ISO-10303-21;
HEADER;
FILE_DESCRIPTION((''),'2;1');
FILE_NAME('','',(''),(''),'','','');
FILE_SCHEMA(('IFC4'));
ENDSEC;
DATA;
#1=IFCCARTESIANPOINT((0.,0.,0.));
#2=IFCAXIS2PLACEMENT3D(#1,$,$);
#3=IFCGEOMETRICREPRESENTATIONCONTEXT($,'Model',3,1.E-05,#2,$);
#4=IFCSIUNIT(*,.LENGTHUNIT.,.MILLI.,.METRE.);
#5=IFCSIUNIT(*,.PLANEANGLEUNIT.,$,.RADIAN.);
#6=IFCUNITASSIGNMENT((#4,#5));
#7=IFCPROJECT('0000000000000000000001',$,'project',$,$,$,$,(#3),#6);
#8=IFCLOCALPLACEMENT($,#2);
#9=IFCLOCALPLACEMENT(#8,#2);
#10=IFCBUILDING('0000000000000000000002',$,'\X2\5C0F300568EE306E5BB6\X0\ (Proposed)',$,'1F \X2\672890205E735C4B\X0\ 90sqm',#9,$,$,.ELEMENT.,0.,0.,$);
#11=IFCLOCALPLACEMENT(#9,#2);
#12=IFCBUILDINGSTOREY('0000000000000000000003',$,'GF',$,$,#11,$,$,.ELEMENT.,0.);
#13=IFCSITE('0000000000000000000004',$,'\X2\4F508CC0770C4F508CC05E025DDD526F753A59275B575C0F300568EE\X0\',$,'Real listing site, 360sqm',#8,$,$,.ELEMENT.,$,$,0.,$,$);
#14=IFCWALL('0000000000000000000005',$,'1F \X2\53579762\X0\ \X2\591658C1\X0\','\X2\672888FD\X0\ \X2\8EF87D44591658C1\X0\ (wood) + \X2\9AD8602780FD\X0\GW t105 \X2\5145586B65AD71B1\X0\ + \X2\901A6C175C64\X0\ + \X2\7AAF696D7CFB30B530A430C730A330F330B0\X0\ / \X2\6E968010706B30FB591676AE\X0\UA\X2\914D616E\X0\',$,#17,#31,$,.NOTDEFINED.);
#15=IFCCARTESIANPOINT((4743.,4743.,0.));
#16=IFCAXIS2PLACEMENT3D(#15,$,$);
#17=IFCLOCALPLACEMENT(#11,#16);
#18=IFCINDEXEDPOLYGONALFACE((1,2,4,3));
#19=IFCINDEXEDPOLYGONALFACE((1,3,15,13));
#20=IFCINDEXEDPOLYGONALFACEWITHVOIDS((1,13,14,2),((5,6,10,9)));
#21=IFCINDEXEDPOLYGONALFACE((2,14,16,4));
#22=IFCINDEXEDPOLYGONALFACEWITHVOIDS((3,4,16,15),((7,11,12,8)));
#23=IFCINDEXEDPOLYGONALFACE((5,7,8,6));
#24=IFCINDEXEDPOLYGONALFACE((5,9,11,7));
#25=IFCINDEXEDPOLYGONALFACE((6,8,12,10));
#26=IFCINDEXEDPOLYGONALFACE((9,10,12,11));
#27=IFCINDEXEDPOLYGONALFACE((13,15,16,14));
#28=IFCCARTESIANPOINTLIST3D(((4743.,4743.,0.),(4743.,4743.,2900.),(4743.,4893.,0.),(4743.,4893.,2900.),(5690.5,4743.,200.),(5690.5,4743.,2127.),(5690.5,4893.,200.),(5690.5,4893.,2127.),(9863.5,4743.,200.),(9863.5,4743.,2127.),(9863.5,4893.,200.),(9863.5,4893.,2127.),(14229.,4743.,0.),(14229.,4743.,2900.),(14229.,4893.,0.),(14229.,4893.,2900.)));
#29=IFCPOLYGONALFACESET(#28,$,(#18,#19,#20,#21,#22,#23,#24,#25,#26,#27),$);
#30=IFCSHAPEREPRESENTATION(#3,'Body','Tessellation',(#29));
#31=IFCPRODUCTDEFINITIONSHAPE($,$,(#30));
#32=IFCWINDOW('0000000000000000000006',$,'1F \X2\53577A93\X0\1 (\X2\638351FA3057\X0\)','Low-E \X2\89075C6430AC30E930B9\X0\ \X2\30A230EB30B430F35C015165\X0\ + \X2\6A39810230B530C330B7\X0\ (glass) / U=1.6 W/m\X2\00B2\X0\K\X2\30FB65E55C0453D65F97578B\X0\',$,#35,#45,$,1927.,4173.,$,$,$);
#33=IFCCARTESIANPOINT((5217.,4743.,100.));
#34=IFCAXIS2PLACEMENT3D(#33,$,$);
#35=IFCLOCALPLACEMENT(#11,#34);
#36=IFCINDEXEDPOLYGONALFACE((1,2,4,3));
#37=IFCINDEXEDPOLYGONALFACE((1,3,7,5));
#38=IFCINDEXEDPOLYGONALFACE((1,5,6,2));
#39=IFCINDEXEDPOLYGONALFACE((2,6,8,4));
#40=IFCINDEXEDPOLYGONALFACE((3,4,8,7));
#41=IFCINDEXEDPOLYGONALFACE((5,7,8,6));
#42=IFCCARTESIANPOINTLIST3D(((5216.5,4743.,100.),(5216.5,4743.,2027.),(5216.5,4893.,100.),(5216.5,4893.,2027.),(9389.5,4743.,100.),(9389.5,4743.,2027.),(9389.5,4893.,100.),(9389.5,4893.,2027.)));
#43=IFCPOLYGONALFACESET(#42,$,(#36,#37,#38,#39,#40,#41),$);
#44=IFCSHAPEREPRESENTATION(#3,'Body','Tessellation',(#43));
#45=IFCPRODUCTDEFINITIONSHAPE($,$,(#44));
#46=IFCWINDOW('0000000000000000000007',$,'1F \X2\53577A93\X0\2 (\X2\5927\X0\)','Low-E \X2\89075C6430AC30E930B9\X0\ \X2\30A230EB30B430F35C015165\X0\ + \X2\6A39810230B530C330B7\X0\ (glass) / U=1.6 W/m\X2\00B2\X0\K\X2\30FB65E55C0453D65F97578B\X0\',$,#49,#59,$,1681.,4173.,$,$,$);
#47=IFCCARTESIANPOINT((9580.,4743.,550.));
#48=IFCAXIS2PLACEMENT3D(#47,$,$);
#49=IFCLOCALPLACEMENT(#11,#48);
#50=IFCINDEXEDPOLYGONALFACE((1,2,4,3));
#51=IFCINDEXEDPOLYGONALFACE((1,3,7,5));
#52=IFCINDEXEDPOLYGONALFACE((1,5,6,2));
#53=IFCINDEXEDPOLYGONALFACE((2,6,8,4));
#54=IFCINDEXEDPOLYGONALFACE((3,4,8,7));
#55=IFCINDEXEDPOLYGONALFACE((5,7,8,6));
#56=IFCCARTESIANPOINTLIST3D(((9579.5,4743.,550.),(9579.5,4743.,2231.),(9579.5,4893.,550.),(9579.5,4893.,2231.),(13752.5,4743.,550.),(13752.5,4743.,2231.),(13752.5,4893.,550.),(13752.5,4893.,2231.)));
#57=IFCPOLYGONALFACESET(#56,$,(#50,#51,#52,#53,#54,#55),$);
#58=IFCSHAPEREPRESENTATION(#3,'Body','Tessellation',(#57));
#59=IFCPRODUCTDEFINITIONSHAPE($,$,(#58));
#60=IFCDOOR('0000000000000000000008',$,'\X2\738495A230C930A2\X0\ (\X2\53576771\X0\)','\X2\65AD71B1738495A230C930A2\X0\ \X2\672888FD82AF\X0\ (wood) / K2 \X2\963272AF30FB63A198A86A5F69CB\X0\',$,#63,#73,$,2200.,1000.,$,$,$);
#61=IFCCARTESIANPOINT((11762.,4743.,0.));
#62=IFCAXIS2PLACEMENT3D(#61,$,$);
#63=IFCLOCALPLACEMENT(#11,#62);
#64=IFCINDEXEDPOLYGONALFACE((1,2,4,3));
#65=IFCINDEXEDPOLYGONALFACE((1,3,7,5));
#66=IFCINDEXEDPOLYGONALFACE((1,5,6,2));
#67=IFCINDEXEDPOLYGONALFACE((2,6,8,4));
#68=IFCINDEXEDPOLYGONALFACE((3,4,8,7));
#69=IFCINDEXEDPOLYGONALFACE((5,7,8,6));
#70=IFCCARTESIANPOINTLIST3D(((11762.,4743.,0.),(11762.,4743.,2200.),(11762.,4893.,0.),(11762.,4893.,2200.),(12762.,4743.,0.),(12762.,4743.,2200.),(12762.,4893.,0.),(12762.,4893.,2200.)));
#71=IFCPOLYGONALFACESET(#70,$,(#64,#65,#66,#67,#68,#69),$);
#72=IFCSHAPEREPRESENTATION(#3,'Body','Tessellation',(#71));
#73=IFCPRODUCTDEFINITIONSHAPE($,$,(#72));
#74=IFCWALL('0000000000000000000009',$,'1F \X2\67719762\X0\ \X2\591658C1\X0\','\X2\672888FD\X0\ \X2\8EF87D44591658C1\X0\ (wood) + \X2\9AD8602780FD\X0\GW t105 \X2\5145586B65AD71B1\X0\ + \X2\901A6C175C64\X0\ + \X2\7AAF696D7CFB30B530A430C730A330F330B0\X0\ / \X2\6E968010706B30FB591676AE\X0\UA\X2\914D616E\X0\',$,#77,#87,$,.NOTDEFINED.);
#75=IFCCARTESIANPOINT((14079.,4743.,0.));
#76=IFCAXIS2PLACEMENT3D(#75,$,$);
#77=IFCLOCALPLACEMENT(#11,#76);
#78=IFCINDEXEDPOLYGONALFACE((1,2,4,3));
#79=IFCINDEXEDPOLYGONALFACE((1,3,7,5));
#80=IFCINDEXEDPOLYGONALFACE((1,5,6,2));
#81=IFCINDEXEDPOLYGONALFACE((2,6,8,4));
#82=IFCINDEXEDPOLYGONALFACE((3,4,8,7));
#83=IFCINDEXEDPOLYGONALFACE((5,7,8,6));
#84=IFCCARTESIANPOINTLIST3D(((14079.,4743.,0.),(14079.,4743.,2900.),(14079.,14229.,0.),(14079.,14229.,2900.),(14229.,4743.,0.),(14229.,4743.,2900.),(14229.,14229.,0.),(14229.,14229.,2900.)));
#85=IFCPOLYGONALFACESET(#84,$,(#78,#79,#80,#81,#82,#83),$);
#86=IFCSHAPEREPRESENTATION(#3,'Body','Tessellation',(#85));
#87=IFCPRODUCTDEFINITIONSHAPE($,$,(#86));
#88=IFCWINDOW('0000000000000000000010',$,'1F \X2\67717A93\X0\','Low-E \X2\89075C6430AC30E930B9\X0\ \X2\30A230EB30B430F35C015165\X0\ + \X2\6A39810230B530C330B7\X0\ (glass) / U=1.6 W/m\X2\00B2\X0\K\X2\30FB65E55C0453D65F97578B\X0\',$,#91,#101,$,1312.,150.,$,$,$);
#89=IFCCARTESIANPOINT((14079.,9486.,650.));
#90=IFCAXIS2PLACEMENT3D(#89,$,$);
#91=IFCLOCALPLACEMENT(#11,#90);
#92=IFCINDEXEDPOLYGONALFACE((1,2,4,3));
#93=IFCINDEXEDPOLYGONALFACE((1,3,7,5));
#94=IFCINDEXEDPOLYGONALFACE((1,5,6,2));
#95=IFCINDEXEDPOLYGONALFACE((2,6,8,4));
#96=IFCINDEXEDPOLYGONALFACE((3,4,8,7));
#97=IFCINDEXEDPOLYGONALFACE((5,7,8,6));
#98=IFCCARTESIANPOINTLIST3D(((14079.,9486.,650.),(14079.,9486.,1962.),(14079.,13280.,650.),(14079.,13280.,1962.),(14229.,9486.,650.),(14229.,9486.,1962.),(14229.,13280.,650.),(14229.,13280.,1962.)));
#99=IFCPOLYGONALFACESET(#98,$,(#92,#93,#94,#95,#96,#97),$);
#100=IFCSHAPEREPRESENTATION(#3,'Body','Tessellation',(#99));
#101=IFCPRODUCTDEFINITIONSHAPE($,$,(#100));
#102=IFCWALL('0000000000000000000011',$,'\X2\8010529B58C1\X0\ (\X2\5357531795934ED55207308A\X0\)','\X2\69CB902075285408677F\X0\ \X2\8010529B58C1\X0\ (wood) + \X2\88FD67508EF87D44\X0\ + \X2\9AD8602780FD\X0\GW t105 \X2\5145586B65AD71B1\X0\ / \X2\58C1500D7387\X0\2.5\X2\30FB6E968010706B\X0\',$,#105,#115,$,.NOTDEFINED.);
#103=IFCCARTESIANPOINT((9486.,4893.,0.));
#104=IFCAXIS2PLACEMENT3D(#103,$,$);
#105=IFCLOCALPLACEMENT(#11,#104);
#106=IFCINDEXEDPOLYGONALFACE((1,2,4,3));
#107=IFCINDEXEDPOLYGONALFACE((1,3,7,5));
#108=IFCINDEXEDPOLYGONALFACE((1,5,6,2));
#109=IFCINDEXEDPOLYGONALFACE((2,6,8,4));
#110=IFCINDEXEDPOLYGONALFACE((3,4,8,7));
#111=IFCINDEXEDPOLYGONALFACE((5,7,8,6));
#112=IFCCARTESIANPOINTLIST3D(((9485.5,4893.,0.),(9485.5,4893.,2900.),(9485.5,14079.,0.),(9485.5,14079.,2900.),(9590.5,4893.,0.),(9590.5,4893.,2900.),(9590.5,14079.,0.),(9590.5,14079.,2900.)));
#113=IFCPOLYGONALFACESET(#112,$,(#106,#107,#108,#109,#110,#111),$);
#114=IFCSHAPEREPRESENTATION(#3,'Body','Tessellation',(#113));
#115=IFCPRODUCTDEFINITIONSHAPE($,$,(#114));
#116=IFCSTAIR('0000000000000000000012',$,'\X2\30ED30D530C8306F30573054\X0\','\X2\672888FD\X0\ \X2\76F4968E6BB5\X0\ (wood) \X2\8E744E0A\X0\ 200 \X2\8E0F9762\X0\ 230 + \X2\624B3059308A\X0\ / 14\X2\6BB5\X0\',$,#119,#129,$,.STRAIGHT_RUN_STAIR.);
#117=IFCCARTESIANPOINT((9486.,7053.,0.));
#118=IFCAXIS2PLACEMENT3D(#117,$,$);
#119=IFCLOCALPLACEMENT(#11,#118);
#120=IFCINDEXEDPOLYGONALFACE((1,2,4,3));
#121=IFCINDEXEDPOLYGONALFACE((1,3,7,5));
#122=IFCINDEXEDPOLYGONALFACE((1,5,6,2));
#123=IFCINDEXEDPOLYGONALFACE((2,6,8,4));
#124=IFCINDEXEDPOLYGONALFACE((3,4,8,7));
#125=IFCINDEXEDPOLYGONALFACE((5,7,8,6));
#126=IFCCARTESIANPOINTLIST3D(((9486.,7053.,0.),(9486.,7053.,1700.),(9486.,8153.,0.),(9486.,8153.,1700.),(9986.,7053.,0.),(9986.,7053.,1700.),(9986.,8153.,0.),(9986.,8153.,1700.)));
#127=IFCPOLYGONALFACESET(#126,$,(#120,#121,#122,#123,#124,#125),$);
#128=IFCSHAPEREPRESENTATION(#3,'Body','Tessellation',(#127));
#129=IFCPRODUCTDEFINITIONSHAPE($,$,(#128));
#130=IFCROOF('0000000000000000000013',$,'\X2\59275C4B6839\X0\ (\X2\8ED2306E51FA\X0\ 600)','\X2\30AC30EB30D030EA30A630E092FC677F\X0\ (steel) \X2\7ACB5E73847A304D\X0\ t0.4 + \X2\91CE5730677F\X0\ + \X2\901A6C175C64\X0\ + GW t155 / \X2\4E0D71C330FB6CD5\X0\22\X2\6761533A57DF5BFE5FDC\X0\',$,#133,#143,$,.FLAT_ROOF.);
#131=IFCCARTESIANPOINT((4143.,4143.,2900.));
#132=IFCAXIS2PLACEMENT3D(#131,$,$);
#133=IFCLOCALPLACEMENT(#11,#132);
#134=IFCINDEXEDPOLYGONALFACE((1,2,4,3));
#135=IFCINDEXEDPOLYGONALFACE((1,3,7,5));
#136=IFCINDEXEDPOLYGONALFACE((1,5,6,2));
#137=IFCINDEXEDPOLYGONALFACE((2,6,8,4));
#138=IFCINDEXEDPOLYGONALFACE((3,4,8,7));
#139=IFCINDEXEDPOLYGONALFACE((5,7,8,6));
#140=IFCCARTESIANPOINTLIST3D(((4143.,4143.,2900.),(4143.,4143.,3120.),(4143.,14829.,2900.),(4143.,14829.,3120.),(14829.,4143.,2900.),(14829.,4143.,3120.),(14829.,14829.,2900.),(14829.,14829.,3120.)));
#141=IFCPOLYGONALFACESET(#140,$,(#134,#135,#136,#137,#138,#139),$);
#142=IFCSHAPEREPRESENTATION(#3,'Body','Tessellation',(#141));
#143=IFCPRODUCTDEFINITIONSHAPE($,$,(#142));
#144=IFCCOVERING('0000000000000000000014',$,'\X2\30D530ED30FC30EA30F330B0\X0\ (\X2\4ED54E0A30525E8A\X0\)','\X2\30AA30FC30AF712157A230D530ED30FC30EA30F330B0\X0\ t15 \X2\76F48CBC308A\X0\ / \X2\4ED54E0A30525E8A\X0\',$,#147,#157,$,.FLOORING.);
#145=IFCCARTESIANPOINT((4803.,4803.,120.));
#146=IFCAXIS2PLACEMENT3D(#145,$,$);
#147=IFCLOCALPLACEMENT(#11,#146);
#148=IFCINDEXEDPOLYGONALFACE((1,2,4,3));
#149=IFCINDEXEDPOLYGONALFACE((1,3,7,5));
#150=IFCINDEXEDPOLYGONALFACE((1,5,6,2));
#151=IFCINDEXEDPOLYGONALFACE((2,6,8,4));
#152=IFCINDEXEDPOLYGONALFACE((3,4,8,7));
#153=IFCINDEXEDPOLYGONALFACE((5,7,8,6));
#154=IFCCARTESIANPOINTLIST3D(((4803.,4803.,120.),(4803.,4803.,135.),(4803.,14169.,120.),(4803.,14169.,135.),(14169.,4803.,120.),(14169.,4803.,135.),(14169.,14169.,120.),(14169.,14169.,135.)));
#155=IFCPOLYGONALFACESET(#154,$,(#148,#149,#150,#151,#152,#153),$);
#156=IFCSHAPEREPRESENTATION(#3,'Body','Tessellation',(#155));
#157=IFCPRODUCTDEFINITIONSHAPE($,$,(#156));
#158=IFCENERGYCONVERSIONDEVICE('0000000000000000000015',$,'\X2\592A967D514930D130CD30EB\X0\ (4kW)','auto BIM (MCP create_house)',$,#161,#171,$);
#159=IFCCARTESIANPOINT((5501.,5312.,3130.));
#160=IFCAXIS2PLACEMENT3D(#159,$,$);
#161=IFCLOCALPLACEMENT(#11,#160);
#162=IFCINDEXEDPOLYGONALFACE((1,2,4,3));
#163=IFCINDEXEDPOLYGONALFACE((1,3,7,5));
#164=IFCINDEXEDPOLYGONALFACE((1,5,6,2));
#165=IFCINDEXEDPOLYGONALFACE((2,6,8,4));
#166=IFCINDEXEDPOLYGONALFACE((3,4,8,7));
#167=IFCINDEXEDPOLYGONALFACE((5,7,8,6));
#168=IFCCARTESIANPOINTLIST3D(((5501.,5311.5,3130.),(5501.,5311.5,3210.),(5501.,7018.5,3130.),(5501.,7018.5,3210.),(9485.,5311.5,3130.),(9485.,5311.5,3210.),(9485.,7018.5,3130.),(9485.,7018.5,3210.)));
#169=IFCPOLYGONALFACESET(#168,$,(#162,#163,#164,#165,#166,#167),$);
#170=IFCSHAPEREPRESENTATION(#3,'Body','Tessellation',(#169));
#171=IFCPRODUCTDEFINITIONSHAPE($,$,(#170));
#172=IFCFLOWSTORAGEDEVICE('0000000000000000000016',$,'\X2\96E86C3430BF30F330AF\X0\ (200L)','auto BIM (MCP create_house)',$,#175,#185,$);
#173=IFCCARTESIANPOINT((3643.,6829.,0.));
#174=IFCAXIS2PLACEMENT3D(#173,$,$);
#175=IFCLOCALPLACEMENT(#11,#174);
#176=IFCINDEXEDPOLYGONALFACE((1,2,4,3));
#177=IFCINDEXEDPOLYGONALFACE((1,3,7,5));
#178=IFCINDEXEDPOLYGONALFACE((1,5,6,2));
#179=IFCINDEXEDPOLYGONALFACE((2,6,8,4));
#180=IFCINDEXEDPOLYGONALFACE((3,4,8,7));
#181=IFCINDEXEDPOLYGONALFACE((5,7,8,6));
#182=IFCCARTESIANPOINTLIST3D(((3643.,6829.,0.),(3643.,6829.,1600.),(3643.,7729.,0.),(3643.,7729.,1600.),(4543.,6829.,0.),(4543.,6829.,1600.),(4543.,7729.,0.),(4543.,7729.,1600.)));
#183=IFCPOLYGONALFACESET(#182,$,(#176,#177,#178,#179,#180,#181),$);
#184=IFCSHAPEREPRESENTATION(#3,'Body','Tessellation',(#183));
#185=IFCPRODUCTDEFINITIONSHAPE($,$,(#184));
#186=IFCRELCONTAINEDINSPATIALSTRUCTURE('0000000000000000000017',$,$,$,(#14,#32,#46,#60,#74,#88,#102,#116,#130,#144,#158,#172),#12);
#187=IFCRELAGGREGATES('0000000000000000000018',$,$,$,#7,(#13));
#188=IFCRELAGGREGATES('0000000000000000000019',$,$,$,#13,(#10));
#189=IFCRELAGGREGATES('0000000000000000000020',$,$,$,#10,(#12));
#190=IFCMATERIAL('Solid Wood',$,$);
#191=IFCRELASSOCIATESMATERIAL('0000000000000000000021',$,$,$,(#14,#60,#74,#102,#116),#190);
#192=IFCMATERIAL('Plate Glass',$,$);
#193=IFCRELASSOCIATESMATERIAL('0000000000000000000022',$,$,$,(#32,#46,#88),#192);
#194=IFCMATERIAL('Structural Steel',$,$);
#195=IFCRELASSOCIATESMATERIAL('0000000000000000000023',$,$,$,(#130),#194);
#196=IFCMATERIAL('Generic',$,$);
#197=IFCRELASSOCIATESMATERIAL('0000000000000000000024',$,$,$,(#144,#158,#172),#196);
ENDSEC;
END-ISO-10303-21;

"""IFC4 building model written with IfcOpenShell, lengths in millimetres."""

from ifc_helpers import new_model, si_unit, frame, frame_2d, origin, place, context, project, spatial, rectangle, extrude, material, element, fill, save


model = new_model("IFC4")

# Units and contexts
model_context = context("Model", 3, precision=1e-05, world=origin())
ifc_project = project(units=[si_unit("LENGTHUNIT", "METRE", prefix="MILLI"), si_unit("PLANEANGLEUNIT", "RADIAN")], contexts=[model_context])

# Site, building, storey
site_placement = place(None, origin())
site = spatial("IfcSite", under=ifc_project, at=site_placement, Name="佐賀県佐賀市川副町大字小々森", ObjectType="Real listing site, 360sqm", CompositionType="ELEMENT", RefElevation=0.0)
building_placement = place(site_placement, origin())
building = spatial("IfcBuilding", under=site, at=building_placement, Name="小々森の家 (Proposed)", ObjectType="1F 木造平屋 90sqm", CompositionType="ELEMENT", ElevationOfRefHeight=0.0, ElevationOfTerrain=0.0)
storey_placement = place(building_placement, origin())
storey = spatial("IfcBuildingStorey", under=building, at=storey_placement, Name="GF", CompositionType="ELEMENT", Elevation=0.0)

# Shared definitions
ifc_material_1 = material(Name="Solid Wood")

# Wall, openings, windows, door
wall_1_placement = place(storey_placement, frame((4743.0, 4743.0, 0.0)))
wall_1 = element("IfcWall", 1, at=wall_1_placement, inside=storey, material=ifc_material_1, Name="1F 南面 外壁", Description="木製 軸組外壁 (wood) + 高性能GW t105 充填断熱 + 通気層 + 窯業系サイディング / 準耐火・外皮UA配慮", PredefinedType="NOTDEFINED", context=model_context, shape_type="SweptSolid", body=[
    extrude(rectangle(XDim=9486.0, YDim=150.0, at=frame_2d((4743.0, 75.0))), frame((4743.0, 4743.0, 0.0)), (0.0, 0.0, 1.0), 2900.0),
])
opening_1_placement = place(storey_placement, frame((5217.0, 4743.0, 100.0)))
opening_1 = element("IfcOpeningElement", 2, at=opening_1_placement, cuts=wall_1, PredefinedType="NOTDEFINED", context=model_context, shape_type="SweptSolid", body=[
    extrude(rectangle(XDim=4173.0, YDim=150.0, at=frame_2d((2086.0, 75.0))), frame((5217.0, 4743.0, 100.0)), (0.0, 0.0, 1.0), 1927.0),
])
opening_2_placement = place(storey_placement, frame((9580.0, 4743.0, 550.0)))
opening_2 = element("IfcOpeningElement", 3, at=opening_2_placement, cuts=wall_1, PredefinedType="NOTDEFINED", context=model_context, shape_type="SweptSolid", body=[
    extrude(rectangle(XDim=4173.0, YDim=150.0, at=frame_2d((2086.0, 75.0))), frame((9580.0, 4743.0, 550.0)), (0.0, 0.0, 1.0), 1681.0),
])
opening_3_placement = place(storey_placement, frame((11762.0, 4743.0, 0.0)))
opening_3 = element("IfcOpeningElement", 4, at=opening_3_placement, cuts=wall_1, PredefinedType="NOTDEFINED", context=model_context, shape_type="SweptSolid", body=[
    extrude(rectangle(XDim=1000.0, YDim=150.0, at=frame_2d((500.0, 75.0))), frame((11762.0, 4743.0, 0.0)), (0.0, 0.0, 1.0), 2200.0),
])
ifc_material_2 = material(Name="Plate Glass")
window_1_placement = place(storey_placement, frame((5217.0, 4743.0, 100.0)))
window_1 = element("IfcWindow", 5, at=window_1_placement, inside=storey, material=ifc_material_2, Name="1F 南窓1 (掃出し)", Description="Low-E 複層ガラス アルゴン封入 + 樹脂サッシ (glass) / U=1.6 W/m²K・日射取得型", OverallHeight=1927.0, OverallWidth=4173.0, context=model_context, shape_type="SweptSolid", body=[
    extrude(rectangle(XDim=4173.0, YDim=150.0, at=frame_2d((2086.0, 75.0))), frame((5217.0, 4743.0, 100.0)), (0.0, 0.0, 1.0), 1927.0),
])
fill(opening_1, window_1)
window_2_placement = place(storey_placement, frame((9580.0, 4743.0, 550.0)))
window_2 = element("IfcWindow", 6, at=window_2_placement, inside=storey, material=ifc_material_2, Name="1F 南窓2 (大)", Description="Low-E 複層ガラス アルゴン封入 + 樹脂サッシ (glass) / U=1.6 W/m²K・日射取得型", OverallHeight=1681.0, OverallWidth=4173.0, context=model_context, shape_type="SweptSolid", body=[
    extrude(rectangle(XDim=4173.0, YDim=150.0, at=frame_2d((2086.0, 75.0))), frame((9580.0, 4743.0, 550.0)), (0.0, 0.0, 1.0), 1681.0),
])
fill(opening_2, window_2)
door_placement = place(storey_placement, frame((11762.0, 4743.0, 0.0)))
door = element("IfcDoor", 7, at=door_placement, inside=storey, material=ifc_material_1, Name="玄関ドア (南東)", Description="断熱玄関ドア 木製芯 (wood) / K2 防犯・採風機構", OverallHeight=2200.0, OverallWidth=1000.0, context=model_context, shape_type="SweptSolid", body=[
    extrude(rectangle(XDim=1000.0, YDim=150.0, at=frame_2d((500.0, 75.0))), frame((11762.0, 4743.0, 0.0)), (0.0, 0.0, 1.0), 2200.0),
])
fill(opening_3, door)

# Wall, opening, window
wall_2_placement = place(storey_placement, frame((14079.0, 4743.0, 0.0)))
wall_2 = element("IfcWall", 8, at=wall_2_placement, inside=storey, material=ifc_material_1, Name="1F 東面 外壁", Description="木製 軸組外壁 (wood) + 高性能GW t105 充填断熱 + 通気層 + 窯業系サイディング / 準耐火・外皮UA配慮", PredefinedType="NOTDEFINED", context=model_context, shape_type="SweptSolid", body=[
    extrude(rectangle(XDim=150.0, YDim=9486.0, at=frame_2d((75.0, 4743.0))), frame((14079.0, 4743.0, 0.0)), (0.0, 0.0, 1.0), 2900.0),
])
opening_4_placement = place(storey_placement, frame((14079.0, 9486.0, 650.0)))
opening_4 = element("IfcOpeningElement", 9, at=opening_4_placement, cuts=wall_2, PredefinedType="NOTDEFINED", context=model_context, shape_type="SweptSolid", body=[
    extrude(rectangle(XDim=150.0, YDim=3794.0, at=frame_2d((75.0, 1897.0))), frame((14079.0, 9486.0, 650.0)), (0.0, 0.0, 1.0), 1312.0),
])
window_3_placement = place(storey_placement, frame((14079.0, 9486.0, 650.0)))
window_3 = element("IfcWindow", 10, at=window_3_placement, inside=storey, material=ifc_material_2, Name="1F 東窓", Description="Low-E 複層ガラス アルゴン封入 + 樹脂サッシ (glass) / U=1.6 W/m²K・日射取得型", OverallHeight=1312.0, OverallWidth=150.0, context=model_context, shape_type="SweptSolid", body=[
    extrude(rectangle(XDim=150.0, YDim=3794.0, at=frame_2d((75.0, 1897.0))), frame((14079.0, 9486.0, 650.0)), (0.0, 0.0, 1.0), 1312.0),
])
fill(opening_4, window_3)

# Wall
wall_3_placement = place(storey_placement, frame((9486.0, 4893.0, 0.0)))
element("IfcWall", 11, at=wall_3_placement, inside=storey, material=ifc_material_1, Name="耐力壁 (南北間仕切り)", Description="構造用合板 耐力壁 (wood) + 製材軸組 + 高性能GW t105 充填断熱 / 壁倍率2.5・準耐火", PredefinedType="NOTDEFINED", context=model_context, shape_type="SweptSolid", body=[
    extrude(rectangle(XDim=105.0, YDim=9186.0, at=frame_2d((52.0, 4593.0))), frame((9486.0, 4893.0, 0.0)), (0.0, 0.0, 1.0), 2900.0),
])

# Stair
stair_placement = place(storey_placement, frame((9486.0, 7053.0, 0.0)))
element("IfcStair", 12, at=stair_placement, inside=storey, material=ifc_material_1, Name="ロフトはしご", Description="木製 直階段 (wood) 蹴上 200 踏面 230 + 手すり / 14段", PredefinedType="STRAIGHT_RUN_STAIR", context=model_context, shape_type="SweptSolid", body=[
    extrude(rectangle(XDim=500.0, YDim=1100.0, at=frame_2d((250.0, 550.0))), frame((9486.0, 7053.0, 0.0)), (0.0, 0.0, 1.0), 1700.0),
])

# Roof
ifc_material_3 = material(Name="Structural Steel")
roof_placement = place(storey_placement, frame((4143.0, 4143.0, 2900.0)))
element("IfcRoof", 13, at=roof_placement, inside=storey, material=ifc_material_3, Name="大屋根 (軒の出 600)", Description="ガルバリウム鋼板 (steel) 立平葺き t0.4 + 野地板 + 通気層 + GW t155 / 不燃・法22条区域対応", PredefinedType="FLAT_ROOF", context=model_context, shape_type="SweptSolid", body=[
    extrude(rectangle(XDim=10686.0, YDim=10686.0, at=frame_2d((5343.0, 5343.0))), frame((4143.0, 4143.0, 2900.0)), (0.0, 0.0, 1.0), 220.0),
])

# Covering
ifc_material_4 = material(Name="Generic")
covering_placement = place(storey_placement, frame((4803.0, 4803.0, 120.0)))
element("IfcCovering", 14, at=covering_placement, inside=storey, material=ifc_material_4, Name="フローリング (仕上げ床)", Description="オーク無垢フローリング t15 直貼り / 仕上げ床", PredefinedType="FLOORING", context=model_context, shape_type="SweptSolid", body=[
    extrude(rectangle(XDim=9366.0, YDim=9366.0, at=frame_2d((4683.0, 4683.0))), frame((4803.0, 4803.0, 120.0)), (0.0, 0.0, 1.0), 15.0),
])

# Energy conversion device
energy_conversion_device_placement = place(storey_placement, frame((5501.0, 5312.0, 3130.0)))
element("IfcEnergyConversionDevice", 15, at=energy_conversion_device_placement, inside=storey, material=ifc_material_4, Name="太陽光パネル (4kW)", Description="auto BIM (MCP create_house)", context=model_context, shape_type="SweptSolid", body=[
    extrude(rectangle(XDim=3984.0, YDim=1707.0, at=frame_2d((1992.0, 853.0))), frame((5501.0, 5312.0, 3130.0)), (0.0, 0.0, 1.0), 80.0),
])

# Flow storage device
flow_storage_device_placement = place(storey_placement, frame((3643.0, 6829.0, 0.0)))
element("IfcFlowStorageDevice", 16, at=flow_storage_device_placement, inside=storey, material=ifc_material_4, Name="雨水タンク (200L)", Description="auto BIM (MCP create_house)", context=model_context, shape_type="SweptSolid", body=[
    extrude(rectangle(XDim=900.0, YDim=900.0, at=frame_2d((450.0, 450.0))), frame((3643.0, 6829.0, 0.0)), (0.0, 0.0, 1.0), 1600.0),
])

save(model, "model.ifc")
